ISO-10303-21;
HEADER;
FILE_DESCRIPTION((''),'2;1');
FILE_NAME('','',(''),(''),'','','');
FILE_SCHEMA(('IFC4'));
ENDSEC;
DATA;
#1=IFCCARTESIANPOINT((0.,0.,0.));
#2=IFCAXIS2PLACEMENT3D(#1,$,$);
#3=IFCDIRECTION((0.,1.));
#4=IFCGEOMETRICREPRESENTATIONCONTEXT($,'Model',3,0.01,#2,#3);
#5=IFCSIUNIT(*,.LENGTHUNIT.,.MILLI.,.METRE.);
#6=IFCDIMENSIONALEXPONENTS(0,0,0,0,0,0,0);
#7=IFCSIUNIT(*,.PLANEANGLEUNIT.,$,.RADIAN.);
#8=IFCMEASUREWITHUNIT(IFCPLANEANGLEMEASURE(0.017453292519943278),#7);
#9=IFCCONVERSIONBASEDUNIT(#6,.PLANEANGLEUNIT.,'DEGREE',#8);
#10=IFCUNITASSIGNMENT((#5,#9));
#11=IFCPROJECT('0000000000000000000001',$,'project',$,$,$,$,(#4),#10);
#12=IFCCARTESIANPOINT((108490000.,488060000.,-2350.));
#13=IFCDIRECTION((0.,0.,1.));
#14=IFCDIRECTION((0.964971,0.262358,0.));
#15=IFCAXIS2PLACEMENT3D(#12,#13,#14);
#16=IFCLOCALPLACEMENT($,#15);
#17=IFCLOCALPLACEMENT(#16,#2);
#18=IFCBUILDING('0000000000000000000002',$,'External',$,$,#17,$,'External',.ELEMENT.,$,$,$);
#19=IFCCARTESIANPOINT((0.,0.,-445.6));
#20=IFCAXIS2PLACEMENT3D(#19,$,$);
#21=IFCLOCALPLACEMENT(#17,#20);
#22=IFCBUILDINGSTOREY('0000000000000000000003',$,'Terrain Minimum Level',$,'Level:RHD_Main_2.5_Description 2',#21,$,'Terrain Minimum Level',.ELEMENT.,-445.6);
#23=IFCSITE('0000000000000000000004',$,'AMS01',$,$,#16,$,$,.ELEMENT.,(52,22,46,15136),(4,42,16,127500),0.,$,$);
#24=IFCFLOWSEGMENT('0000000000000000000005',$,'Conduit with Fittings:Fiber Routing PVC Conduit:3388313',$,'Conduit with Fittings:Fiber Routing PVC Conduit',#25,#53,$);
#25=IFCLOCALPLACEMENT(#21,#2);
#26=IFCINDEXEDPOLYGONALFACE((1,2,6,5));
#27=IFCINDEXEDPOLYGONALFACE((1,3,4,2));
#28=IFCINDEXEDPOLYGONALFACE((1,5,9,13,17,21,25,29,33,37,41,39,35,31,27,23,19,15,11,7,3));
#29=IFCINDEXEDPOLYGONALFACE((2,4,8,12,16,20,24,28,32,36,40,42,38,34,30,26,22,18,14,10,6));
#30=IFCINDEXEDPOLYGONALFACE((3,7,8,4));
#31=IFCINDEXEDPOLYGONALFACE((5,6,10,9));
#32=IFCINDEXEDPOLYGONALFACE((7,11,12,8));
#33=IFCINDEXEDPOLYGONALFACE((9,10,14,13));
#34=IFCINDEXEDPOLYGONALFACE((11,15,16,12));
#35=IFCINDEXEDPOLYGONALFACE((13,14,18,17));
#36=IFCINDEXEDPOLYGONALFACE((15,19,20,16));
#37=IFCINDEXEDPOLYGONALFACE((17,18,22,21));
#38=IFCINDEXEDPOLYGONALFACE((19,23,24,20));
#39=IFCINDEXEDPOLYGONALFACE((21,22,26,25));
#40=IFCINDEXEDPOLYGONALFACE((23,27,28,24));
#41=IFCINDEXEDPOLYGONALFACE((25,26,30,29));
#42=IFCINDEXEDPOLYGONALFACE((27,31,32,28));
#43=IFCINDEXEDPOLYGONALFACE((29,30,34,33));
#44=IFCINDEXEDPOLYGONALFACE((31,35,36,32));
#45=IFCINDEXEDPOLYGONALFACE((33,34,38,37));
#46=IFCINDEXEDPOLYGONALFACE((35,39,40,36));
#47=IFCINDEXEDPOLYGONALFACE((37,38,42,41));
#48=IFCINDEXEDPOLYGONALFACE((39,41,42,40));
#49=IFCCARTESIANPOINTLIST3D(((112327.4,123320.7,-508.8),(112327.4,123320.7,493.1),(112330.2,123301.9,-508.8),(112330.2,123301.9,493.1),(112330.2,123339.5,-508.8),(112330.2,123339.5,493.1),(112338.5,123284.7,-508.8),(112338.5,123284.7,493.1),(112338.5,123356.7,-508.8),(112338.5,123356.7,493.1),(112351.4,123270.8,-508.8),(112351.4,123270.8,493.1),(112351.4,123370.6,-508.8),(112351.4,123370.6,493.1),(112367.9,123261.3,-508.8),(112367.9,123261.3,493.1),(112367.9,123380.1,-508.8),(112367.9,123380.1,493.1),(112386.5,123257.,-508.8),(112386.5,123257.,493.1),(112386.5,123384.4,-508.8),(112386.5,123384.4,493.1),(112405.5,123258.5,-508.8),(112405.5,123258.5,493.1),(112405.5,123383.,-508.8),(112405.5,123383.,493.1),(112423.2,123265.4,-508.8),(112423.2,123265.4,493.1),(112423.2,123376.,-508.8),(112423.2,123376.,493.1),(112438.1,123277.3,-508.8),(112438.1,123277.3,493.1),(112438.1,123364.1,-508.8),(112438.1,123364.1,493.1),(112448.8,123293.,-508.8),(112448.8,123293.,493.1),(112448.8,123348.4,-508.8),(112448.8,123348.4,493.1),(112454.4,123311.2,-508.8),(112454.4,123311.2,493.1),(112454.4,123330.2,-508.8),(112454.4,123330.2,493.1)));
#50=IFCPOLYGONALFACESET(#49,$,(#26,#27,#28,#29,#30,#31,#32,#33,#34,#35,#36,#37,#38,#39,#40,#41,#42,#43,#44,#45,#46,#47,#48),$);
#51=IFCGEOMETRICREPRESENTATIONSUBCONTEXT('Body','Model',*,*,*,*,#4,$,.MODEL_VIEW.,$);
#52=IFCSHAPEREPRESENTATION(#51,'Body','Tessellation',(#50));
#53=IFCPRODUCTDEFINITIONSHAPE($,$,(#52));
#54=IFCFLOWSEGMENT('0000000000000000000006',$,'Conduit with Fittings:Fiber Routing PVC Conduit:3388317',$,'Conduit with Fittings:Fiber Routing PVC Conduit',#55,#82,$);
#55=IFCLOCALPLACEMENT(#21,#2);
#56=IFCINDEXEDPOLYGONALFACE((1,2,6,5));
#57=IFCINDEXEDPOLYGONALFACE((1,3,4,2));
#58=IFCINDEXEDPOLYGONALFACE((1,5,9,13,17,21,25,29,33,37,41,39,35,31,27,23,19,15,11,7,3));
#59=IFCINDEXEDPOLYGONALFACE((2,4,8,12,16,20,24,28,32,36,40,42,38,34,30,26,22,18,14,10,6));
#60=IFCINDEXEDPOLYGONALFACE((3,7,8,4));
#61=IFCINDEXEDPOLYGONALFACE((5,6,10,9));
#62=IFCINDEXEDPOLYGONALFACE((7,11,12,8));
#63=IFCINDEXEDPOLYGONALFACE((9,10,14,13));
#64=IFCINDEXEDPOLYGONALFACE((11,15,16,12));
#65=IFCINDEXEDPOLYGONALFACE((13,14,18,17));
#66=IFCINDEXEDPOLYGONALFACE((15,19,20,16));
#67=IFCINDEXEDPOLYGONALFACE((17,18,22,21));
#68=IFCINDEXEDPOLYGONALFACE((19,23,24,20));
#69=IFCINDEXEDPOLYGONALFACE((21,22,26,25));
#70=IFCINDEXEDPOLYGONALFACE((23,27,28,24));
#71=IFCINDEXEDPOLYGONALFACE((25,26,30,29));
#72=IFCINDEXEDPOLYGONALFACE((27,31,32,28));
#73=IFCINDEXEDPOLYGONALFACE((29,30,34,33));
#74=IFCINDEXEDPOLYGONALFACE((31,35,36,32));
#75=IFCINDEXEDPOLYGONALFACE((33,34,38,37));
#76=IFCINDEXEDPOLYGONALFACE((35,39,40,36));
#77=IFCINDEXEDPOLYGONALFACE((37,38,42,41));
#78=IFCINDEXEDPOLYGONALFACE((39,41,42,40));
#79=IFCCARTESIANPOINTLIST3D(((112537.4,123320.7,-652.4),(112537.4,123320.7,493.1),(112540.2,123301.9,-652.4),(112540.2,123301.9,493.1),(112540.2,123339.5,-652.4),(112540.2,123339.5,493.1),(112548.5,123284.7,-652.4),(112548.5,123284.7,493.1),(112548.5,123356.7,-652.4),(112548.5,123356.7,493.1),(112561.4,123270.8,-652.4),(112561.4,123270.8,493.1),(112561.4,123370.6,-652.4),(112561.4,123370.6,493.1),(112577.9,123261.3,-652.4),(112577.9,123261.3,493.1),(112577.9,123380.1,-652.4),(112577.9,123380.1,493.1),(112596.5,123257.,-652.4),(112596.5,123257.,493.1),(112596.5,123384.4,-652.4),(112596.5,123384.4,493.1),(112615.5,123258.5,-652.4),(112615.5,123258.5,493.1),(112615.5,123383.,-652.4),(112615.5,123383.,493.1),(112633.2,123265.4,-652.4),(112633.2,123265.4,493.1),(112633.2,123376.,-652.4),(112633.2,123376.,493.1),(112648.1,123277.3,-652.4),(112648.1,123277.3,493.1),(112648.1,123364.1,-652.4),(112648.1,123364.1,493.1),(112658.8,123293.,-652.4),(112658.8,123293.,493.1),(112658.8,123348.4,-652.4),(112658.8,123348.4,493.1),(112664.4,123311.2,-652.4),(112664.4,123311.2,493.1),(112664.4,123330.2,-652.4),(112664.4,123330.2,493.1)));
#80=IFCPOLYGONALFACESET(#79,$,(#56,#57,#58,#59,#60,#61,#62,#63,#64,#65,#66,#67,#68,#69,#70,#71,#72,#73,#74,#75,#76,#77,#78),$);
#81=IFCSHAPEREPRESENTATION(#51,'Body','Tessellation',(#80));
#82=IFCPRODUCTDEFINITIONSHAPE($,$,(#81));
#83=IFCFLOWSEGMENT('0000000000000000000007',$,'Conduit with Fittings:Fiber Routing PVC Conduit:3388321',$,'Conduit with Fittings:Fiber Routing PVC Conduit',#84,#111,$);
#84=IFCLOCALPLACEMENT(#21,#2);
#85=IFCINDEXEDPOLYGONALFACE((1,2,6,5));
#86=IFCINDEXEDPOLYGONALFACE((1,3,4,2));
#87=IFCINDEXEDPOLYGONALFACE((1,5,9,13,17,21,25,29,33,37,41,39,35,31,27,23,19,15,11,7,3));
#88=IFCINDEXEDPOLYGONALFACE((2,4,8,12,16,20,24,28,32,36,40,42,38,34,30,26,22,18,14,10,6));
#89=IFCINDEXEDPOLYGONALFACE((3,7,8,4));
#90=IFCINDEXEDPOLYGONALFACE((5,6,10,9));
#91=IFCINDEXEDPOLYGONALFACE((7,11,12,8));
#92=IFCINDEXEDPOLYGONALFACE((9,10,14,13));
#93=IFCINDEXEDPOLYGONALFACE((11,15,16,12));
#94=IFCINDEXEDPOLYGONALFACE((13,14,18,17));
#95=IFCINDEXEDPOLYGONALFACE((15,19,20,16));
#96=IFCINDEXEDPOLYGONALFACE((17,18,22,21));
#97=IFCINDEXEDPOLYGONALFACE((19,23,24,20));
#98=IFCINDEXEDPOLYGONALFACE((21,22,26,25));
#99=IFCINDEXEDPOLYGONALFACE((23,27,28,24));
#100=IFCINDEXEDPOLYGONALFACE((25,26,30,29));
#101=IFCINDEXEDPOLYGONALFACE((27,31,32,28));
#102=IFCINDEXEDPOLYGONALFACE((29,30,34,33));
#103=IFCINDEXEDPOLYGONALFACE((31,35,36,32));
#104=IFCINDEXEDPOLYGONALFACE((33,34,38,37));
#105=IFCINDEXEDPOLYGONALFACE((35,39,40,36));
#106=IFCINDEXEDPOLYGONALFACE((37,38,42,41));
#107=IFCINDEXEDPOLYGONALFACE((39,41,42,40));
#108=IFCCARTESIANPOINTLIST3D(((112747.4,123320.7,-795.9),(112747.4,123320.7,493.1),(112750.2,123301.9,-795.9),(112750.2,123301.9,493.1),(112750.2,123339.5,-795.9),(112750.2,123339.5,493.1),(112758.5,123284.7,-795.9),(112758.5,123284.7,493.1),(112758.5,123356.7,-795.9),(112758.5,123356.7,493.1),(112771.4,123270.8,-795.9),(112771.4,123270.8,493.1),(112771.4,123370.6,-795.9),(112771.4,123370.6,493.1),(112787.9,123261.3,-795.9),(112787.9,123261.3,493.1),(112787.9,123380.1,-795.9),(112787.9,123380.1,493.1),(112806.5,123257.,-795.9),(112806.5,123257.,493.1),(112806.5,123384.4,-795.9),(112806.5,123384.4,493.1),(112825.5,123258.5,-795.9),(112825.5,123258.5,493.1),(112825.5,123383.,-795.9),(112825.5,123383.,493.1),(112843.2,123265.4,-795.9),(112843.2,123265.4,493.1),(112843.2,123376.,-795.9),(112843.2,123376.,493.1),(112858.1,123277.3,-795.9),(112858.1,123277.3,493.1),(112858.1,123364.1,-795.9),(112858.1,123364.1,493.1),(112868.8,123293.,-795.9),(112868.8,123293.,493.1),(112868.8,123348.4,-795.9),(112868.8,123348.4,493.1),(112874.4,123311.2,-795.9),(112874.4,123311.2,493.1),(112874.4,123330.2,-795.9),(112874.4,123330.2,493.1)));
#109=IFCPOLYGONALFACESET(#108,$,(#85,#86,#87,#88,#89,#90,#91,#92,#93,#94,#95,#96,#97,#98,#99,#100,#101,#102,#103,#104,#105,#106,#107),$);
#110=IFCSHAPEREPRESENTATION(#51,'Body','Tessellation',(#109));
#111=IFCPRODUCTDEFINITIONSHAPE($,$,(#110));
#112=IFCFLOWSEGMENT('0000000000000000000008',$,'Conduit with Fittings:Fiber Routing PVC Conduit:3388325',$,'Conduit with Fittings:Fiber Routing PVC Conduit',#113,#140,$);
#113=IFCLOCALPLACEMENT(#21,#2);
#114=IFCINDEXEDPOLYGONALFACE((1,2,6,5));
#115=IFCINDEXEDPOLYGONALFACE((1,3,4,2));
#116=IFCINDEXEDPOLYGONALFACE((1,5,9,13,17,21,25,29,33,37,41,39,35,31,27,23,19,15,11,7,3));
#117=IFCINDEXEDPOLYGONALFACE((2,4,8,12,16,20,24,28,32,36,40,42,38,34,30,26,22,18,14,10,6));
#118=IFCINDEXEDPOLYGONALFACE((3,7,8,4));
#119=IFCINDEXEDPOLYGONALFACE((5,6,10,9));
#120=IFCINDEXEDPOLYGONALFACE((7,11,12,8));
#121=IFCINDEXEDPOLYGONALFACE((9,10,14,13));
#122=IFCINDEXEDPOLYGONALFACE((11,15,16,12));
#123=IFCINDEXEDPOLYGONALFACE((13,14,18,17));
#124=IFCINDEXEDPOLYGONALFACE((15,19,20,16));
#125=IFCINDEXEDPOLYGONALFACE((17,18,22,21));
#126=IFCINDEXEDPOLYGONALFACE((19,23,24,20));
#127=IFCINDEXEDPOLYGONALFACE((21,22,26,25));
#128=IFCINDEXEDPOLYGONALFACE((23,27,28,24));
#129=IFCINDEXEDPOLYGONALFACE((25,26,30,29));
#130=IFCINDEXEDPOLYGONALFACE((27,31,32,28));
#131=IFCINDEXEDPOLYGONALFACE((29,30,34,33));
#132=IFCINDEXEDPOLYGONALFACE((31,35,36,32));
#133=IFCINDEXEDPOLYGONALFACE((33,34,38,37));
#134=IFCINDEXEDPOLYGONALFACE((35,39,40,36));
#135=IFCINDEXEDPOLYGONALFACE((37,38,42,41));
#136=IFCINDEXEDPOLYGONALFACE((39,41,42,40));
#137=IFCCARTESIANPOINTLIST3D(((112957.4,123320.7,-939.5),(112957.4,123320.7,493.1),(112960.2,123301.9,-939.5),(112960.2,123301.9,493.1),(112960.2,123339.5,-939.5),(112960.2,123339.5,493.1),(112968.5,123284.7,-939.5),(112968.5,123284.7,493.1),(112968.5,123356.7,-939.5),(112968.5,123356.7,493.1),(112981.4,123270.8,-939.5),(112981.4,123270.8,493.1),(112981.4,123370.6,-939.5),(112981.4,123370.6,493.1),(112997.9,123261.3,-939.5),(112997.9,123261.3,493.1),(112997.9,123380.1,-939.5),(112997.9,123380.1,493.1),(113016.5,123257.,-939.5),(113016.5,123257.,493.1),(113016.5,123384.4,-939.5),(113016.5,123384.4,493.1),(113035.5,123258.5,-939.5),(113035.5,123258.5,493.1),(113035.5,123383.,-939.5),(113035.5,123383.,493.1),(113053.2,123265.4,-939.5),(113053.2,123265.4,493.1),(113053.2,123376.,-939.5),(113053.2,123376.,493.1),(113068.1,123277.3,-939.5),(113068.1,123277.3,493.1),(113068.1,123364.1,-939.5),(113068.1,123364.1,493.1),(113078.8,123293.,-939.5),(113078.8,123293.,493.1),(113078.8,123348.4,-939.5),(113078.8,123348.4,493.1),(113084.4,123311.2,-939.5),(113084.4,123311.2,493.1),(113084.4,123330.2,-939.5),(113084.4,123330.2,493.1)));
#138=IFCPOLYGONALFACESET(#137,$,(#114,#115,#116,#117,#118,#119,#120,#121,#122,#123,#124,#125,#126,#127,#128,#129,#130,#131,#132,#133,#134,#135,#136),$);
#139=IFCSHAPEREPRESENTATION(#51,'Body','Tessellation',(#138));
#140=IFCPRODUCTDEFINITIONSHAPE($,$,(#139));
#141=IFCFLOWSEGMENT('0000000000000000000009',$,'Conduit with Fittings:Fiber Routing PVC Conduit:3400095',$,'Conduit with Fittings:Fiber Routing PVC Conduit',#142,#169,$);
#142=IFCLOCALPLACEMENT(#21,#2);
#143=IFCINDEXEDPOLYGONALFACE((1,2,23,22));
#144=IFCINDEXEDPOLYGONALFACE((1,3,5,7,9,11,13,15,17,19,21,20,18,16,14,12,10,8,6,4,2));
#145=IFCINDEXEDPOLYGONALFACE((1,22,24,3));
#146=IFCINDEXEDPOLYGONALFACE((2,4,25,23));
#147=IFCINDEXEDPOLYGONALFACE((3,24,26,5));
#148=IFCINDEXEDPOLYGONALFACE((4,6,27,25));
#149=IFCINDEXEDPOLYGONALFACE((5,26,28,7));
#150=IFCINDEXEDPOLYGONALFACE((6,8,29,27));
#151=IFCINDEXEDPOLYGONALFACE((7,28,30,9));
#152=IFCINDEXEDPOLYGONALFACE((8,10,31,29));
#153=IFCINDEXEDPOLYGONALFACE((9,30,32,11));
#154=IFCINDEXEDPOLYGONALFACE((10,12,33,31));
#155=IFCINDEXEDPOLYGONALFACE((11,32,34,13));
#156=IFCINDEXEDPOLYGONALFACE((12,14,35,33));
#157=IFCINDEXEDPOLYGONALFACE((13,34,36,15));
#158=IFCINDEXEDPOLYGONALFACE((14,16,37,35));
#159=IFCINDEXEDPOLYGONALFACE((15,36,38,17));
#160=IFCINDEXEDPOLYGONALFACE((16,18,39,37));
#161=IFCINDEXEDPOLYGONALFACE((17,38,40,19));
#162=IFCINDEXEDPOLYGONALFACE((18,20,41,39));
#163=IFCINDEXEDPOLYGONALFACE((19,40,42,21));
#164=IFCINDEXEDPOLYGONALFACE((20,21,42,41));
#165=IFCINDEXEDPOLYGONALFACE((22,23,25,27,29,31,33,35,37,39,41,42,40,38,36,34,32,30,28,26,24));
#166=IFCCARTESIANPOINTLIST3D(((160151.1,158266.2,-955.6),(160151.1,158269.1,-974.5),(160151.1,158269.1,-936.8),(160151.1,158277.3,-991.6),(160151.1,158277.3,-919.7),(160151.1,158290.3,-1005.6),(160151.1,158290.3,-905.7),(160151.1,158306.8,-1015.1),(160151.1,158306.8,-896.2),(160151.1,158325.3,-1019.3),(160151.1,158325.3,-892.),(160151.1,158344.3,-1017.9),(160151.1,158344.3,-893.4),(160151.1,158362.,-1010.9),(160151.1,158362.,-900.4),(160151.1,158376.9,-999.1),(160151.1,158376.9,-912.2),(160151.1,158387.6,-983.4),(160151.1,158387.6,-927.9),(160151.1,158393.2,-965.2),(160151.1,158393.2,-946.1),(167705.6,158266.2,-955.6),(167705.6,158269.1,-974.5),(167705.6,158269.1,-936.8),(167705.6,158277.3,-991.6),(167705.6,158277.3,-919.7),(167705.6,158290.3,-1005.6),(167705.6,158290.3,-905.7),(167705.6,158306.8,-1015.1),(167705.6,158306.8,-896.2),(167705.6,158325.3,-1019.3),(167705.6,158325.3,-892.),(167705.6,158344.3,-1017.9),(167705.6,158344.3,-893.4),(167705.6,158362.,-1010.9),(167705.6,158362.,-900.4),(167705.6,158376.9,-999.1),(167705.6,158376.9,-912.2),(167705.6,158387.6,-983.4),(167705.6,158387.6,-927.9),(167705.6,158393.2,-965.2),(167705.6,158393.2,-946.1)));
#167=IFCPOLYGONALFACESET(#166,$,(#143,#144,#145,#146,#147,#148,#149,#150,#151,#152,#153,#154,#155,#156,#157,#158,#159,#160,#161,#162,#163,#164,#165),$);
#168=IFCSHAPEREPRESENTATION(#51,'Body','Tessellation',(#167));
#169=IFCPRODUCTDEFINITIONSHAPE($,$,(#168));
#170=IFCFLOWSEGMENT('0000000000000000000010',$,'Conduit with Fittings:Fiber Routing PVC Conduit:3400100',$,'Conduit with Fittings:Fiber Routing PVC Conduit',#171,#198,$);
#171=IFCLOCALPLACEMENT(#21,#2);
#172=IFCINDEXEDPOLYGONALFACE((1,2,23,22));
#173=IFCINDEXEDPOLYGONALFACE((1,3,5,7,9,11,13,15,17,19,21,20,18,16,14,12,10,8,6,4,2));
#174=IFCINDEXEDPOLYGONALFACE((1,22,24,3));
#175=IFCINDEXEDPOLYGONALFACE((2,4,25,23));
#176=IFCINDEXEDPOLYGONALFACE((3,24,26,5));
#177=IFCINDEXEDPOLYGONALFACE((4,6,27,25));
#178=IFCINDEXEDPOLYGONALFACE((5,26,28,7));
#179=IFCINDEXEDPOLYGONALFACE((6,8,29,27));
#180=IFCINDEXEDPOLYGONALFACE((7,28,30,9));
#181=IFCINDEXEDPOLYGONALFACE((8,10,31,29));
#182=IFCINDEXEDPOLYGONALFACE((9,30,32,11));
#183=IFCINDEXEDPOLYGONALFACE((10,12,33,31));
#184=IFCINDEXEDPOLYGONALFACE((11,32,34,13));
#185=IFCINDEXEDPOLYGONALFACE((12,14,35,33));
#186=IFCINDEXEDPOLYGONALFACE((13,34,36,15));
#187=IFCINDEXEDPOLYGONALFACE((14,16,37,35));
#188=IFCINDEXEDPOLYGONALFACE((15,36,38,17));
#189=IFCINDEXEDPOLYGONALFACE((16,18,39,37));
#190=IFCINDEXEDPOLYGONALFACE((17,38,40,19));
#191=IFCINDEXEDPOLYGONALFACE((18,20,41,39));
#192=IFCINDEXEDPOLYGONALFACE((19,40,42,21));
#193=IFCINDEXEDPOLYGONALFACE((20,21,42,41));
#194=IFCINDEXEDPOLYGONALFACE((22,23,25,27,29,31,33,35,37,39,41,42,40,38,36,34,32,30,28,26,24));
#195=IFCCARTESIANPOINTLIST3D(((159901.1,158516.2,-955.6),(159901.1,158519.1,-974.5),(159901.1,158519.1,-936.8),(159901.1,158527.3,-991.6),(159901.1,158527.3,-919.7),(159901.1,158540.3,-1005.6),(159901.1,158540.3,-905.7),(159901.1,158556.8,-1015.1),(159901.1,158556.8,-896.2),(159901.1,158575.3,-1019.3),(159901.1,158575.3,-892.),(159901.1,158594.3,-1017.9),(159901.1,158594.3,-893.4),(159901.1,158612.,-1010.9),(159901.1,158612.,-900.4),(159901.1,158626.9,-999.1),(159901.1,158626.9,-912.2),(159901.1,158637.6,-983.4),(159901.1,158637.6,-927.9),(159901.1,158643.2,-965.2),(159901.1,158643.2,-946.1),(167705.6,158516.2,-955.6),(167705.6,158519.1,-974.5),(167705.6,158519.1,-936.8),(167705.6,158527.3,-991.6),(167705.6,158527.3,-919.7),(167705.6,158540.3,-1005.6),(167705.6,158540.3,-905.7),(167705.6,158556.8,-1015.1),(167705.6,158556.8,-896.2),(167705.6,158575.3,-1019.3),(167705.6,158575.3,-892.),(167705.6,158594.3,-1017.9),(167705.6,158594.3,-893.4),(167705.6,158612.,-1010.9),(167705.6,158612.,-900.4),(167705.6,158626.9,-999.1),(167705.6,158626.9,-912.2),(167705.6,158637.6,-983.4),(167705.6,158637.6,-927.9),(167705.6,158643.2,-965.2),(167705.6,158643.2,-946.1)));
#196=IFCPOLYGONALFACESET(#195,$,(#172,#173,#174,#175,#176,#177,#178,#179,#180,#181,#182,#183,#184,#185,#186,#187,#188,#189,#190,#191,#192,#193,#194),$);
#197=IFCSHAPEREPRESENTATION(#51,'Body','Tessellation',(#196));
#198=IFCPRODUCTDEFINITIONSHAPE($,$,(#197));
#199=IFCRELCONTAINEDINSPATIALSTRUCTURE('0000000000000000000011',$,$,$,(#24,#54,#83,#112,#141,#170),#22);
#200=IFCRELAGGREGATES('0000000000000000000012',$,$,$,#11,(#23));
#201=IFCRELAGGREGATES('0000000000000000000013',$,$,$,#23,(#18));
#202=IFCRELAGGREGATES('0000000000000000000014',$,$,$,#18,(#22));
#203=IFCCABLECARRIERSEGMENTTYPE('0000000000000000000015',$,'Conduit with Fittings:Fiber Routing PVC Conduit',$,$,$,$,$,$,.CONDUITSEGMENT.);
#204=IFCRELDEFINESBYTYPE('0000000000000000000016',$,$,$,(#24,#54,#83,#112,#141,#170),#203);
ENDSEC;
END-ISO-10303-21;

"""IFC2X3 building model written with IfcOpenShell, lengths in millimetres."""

from ifc_helpers import new_model, entity, si_unit, converted_unit, direction, frame, frame_2d, origin, origin_2d_with_axis, place, context, subcontext, project, spatial, circle, extrude, type_object, element, save


model = new_model("IFC2X3")

# Units and contexts
model_context = context("Model", 3, precision=0.01, world=origin(), true_north=direction((0.0, 1.0)))
body_context = subcontext(model_context, "Body", "Model", "MODEL_VIEW")
ifc_project = project(units=[si_unit("LENGTHUNIT", "METRE", prefix="MILLI"), converted_unit("PLANEANGLEUNIT", "DEGREE", entity("IfcPlaneAngleMeasure", 0.017453292519943278), si_unit("PLANEANGLEUNIT", "RADIAN"), dimensions=[0, 0, 0, 0, 0, 0, 0])], contexts=[model_context])

# Site, building, storey
site_placement = place(None, frame((108490000.0, 488060000.0, -2350.0), z_axis=(0.0, 0.0, 1.0), x_axis=(0.964971, 0.262358, 0.0)))
site = spatial("IfcSite", under=ifc_project, at=site_placement, Name="AMS01", CompositionType="ELEMENT", RefLatitude=(52, 22, 46, 15136), RefLongitude=(4, 42, 16, 127500), RefElevation=0.0)
building_placement = place(site_placement, origin())
building = spatial("IfcBuilding", under=site, at=building_placement, Name="External", LongName="External", CompositionType="ELEMENT")
storey_placement = place(building_placement, frame((0.0, 0.0, -445.6)))
storey = spatial("IfcBuildingStorey", under=building, at=storey_placement, Name="Terrain Minimum Level", ObjectType="Level:RHD_Main_2.5_Description 2", LongName="Terrain Minimum Level", CompositionType="ELEMENT", Elevation=-445.6)

# Flow segments
cable_carrier_segment_type = type_object("IfcCableCarrierSegmentType", Name="Conduit with Fittings:Fiber Routing PVC Conduit", PredefinedType="CONDUITSEGMENT")
flow_segment_1_placement = place(storey_placement, origin())
element("IfcFlowSegment", 1, at=flow_segment_1_placement, inside=storey, type_object=cable_carrier_segment_type, Name="Conduit with Fittings:Fiber Routing PVC Conduit:3388313", ObjectType="Conduit with Fittings:Fiber Routing PVC Conduit", context=body_context, shape_type="SweptSolid", body=[
    extrude(circle(Radius=63.9, at=origin_2d_with_axis()), frame((112391.3, 123320.7, -508.8), z_axis=(0.0, 0.0, 1.0), x_axis=(-1.0, 0.0, 0.0)), (0.0, 0.0, 1.0), 1001.9),
])
flow_segment_2_placement = place(storey_placement, origin())
element("IfcFlowSegment", 2, at=flow_segment_2_placement, inside=storey, type_object=cable_carrier_segment_type, Name="Conduit with Fittings:Fiber Routing PVC Conduit:3388317", ObjectType="Conduit with Fittings:Fiber Routing PVC Conduit", context=body_context, shape_type="SweptSolid", body=[
    extrude(circle(Radius=63.9, at=origin_2d_with_axis()), frame((112601.3, 123320.7, -652.4), z_axis=(0.0, 0.0, 1.0), x_axis=(-1.0, 0.0, 0.0)), (0.0, 0.0, 1.0), 1145.5),
])
flow_segment_3_placement = place(storey_placement, origin())
element("IfcFlowSegment", 3, at=flow_segment_3_placement, inside=storey, type_object=cable_carrier_segment_type, Name="Conduit with Fittings:Fiber Routing PVC Conduit:3388321", ObjectType="Conduit with Fittings:Fiber Routing PVC Conduit", context=body_context, shape_type="SweptSolid", body=[
    extrude(circle(Radius=63.9, at=frame_2d((0.0, 0.0), x_axis=(1.0, 0.0))), frame((112811.3, 123320.7, -795.9), z_axis=(0.0, 0.0, 1.0), x_axis=(-1.0, 0.0, 0.0)), (0.0, 0.0, 1.0), 1289.0),
])
flow_segment_4_placement = place(storey_placement, origin())
element("IfcFlowSegment", 4, at=flow_segment_4_placement, inside=storey, type_object=cable_carrier_segment_type, Name="Conduit with Fittings:Fiber Routing PVC Conduit:3388325", ObjectType="Conduit with Fittings:Fiber Routing PVC Conduit", context=body_context, shape_type="SweptSolid", body=[
    extrude(circle(Radius=63.9, at=frame_2d((0.0, 0.0), x_axis=(1.0, 0.0))), frame((113021.3, 123320.7, -939.5), z_axis=(0.0, 0.0, 1.0), x_axis=(-1.0, 0.0, 0.0)), (0.0, 0.0, 1.0), 1432.6),
])
flow_segment_5_placement = place(storey_placement, origin())
element("IfcFlowSegment", 5, at=flow_segment_5_placement, inside=storey, type_object=cable_carrier_segment_type, Name="Conduit with Fittings:Fiber Routing PVC Conduit:3400095", ObjectType="Conduit with Fittings:Fiber Routing PVC Conduit", context=body_context, shape_type="SweptSolid", body=[
    extrude(circle(Radius=63.9, at=origin_2d_with_axis()), frame((160151.1, 158330.1, -955.6), z_axis=(1.0, 0.0, 0.0), x_axis=(0.0, -1.0, 0.0)), (0.0, 0.0, 1.0), 7554.6),
])
flow_segment_6_placement = place(storey_placement, origin())
element("IfcFlowSegment", 6, at=flow_segment_6_placement, inside=storey, type_object=cable_carrier_segment_type, Name="Conduit with Fittings:Fiber Routing PVC Conduit:3400100", ObjectType="Conduit with Fittings:Fiber Routing PVC Conduit", context=body_context, shape_type="SweptSolid", body=[
    extrude(circle(Radius=63.9, at=origin_2d_with_axis()), frame((159901.1, 158580.1, -955.6), z_axis=(1.0, 0.0, 0.0), x_axis=(0.0, -1.0, 0.0)), (0.0, 0.0, 1.0), 7804.6),
])

save(model, "model.ifc")
